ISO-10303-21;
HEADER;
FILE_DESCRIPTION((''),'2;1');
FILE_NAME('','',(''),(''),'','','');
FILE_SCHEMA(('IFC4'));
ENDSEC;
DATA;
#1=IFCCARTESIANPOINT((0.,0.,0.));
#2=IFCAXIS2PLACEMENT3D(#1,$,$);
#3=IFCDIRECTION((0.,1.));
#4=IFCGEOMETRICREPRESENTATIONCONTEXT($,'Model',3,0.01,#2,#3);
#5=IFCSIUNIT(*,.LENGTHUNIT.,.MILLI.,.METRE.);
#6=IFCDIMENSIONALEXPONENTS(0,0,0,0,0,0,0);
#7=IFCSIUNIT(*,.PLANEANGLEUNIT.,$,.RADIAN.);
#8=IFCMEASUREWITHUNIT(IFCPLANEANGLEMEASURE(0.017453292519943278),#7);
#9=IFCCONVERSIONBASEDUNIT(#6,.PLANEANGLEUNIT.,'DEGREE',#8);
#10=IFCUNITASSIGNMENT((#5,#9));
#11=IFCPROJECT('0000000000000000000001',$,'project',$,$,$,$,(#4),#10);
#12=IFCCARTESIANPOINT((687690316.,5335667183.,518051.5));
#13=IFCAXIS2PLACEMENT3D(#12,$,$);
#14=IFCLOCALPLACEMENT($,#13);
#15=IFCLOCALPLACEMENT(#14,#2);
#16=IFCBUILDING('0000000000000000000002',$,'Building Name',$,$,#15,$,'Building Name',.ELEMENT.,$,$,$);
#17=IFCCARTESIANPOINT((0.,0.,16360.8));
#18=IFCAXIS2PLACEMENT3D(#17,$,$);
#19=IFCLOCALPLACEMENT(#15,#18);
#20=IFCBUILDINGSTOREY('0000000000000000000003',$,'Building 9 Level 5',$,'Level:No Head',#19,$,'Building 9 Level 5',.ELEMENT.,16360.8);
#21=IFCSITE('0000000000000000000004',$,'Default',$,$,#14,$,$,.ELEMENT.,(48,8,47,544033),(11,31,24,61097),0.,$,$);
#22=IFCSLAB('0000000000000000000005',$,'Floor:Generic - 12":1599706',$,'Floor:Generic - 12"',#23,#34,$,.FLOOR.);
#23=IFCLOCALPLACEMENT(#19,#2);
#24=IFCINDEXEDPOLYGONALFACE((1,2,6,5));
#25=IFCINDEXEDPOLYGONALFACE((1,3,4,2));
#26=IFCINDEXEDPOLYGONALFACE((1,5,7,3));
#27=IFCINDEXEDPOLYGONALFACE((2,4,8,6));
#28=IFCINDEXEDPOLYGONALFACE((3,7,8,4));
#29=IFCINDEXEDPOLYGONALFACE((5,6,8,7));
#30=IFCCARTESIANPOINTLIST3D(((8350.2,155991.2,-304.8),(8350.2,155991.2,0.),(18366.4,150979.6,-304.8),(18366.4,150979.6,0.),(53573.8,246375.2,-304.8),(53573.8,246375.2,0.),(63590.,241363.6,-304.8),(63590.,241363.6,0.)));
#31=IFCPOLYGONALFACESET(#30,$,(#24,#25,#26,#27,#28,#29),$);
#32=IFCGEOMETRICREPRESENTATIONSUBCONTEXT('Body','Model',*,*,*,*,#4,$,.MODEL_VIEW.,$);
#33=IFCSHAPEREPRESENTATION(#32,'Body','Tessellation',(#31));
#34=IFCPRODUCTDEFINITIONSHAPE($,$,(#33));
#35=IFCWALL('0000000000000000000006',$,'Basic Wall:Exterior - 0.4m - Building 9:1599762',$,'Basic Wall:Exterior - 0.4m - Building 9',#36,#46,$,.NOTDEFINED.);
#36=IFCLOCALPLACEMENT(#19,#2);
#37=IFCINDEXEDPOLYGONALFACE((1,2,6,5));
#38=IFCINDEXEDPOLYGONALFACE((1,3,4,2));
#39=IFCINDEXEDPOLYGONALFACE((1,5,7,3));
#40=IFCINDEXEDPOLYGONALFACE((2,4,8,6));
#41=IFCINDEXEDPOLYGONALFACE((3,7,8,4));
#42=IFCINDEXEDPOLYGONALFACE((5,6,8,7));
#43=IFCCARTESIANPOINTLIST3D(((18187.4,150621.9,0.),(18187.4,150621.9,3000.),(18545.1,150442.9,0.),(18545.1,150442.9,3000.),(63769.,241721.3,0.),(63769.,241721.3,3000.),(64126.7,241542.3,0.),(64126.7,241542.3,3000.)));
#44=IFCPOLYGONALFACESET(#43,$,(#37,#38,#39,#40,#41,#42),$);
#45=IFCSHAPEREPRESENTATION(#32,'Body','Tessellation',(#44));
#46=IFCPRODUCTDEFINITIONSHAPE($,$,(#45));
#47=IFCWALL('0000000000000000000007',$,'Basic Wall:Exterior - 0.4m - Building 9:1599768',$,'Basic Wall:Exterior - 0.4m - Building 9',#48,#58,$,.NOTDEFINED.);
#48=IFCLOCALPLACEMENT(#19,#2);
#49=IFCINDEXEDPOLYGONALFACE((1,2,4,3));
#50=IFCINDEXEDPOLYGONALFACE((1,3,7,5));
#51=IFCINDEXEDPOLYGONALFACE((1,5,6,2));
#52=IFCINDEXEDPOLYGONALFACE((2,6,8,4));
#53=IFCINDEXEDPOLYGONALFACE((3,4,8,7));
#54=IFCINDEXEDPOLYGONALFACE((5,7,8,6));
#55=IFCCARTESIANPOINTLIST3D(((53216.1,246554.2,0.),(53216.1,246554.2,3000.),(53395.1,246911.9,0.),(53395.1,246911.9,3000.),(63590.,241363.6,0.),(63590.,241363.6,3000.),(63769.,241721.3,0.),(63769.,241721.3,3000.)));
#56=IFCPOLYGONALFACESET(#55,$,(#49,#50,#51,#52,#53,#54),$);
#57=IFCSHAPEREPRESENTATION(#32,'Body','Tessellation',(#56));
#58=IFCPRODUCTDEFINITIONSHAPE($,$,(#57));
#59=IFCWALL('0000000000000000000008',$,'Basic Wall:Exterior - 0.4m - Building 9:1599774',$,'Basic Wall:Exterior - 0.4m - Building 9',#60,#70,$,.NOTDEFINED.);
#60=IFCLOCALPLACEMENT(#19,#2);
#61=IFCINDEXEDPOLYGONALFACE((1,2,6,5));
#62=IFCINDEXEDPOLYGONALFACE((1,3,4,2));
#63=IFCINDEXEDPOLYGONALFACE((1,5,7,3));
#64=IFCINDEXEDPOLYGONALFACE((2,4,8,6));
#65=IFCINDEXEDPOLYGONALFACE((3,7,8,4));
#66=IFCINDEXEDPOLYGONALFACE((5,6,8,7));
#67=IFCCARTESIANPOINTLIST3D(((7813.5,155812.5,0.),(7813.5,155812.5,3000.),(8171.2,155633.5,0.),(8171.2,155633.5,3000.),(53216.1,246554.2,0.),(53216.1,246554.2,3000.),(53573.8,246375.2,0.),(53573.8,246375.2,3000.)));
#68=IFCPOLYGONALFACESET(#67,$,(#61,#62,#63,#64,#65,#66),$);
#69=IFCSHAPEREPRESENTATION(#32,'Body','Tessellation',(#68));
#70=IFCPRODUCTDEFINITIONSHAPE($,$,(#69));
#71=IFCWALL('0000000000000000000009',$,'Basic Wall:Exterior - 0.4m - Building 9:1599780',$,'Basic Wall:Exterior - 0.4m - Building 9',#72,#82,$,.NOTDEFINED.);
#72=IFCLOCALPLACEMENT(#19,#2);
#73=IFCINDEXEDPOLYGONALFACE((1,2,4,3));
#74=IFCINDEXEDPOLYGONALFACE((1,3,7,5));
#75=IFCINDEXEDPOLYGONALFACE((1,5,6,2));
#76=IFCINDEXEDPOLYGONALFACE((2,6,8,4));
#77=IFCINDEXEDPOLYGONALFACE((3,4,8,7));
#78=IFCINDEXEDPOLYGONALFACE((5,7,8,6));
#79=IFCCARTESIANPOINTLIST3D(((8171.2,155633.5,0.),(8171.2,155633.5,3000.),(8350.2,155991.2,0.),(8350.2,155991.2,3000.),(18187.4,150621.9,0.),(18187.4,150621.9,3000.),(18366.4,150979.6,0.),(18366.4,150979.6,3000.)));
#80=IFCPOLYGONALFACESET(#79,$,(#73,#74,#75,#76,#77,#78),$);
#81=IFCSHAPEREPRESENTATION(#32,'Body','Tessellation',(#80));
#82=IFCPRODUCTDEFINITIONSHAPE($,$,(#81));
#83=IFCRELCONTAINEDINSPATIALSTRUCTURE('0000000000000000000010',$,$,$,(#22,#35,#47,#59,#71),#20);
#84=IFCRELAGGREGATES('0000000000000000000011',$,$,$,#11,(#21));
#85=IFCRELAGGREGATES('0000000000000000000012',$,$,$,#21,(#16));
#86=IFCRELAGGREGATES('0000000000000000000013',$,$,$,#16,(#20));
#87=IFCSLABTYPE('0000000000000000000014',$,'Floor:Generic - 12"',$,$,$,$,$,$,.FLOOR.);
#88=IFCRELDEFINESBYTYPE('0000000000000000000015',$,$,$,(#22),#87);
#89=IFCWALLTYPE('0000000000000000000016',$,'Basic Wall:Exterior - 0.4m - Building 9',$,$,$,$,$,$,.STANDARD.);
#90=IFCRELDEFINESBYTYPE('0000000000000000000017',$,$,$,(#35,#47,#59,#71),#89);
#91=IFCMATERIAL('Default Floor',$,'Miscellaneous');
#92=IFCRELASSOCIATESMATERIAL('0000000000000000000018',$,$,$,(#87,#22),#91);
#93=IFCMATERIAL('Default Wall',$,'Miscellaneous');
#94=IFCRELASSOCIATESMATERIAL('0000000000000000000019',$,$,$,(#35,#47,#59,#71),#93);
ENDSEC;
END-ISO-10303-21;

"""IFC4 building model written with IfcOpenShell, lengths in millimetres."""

from ifc_helpers import new_model, entity, si_unit, converted_unit, direction, frame, origin, place, context, subcontext, project, spatial, indexed_curve, outline, extrude, material, type_object, element, save


model = new_model("IFC4")

# Units and contexts
model_context = context("Model", 3, precision=0.01, world=origin(), true_north=direction((0.0, 1.0)))
body_context = subcontext(model_context, "Body", "Model", "MODEL_VIEW")
ifc_project = project(units=[si_unit("LENGTHUNIT", "METRE", prefix="MILLI"), converted_unit("PLANEANGLEUNIT", "DEGREE", entity("IfcPlaneAngleMeasure", 0.017453292519943278), si_unit("PLANEANGLEUNIT", "RADIAN"), dimensions=[0, 0, 0, 0, 0, 0, 0])], contexts=[model_context])

# Site, building, storey
site_placement = place(None, frame((687690316.0, 5335667183.0, 518051.5)))
site = spatial("IfcSite", under=ifc_project, at=site_placement, Name="Default", CompositionType="ELEMENT", RefLatitude=(48, 8, 47, 544033), RefLongitude=(11, 31, 24, 61097), RefElevation=0.0)
building_placement = place(site_placement, origin())
building = spatial("IfcBuilding", under=site, at=building_placement, Name="Building Name", LongName="Building Name", CompositionType="ELEMENT")
storey_placement = place(building_placement, frame((0.0, 0.0, 16360.8)))
storey = spatial("IfcBuildingStorey", under=building, at=storey_placement, Name="Building 9 Level 5", ObjectType="Level:No Head", LongName="Building 9 Level 5", CompositionType="ELEMENT", Elevation=16360.8)

# Slab
ifc_material_1 = material(Name="Default Floor", Category="Miscellaneous")
slab_type = type_object("IfcSlabType", Name="Floor:Generic - 12\"", PredefinedType="FLOOR", material=ifc_material_1)
slab_placement = place(storey_placement, origin())
element("IfcSlab", 1, at=slab_placement, inside=storey, type_object=slab_type, material=ifc_material_1, Name="Floor:Generic - 12\":1599706", ObjectType="Floor:Generic - 12\"", PredefinedType="FLOOR", context=body_context, shape_type="SweptSolid", body=[
    extrude(outline(indexed_curve([(-50533.2, -5600.0), (50533.2, -5600.0), (50533.2, 5600.0), (-50533.2, 5600.0), (-50533.2, -5600.0)], self_intersect=False)), frame((35970.1, 198677.4, 0.0), z_axis=(0.0, 0.0, -1.0), x_axis=(-0.447464, -0.894302, 0.0)), (0.0, 0.0, 1.0), 304.8),
])

# Walls
ifc_material_2 = material(Name="Default Wall", Category="Miscellaneous")
wall_type = type_object("IfcWallType", Name="Basic Wall:Exterior - 0.4m - Building 9", PredefinedType="STANDARD")
wall_1_placement = place(storey_placement, frame((18366.3, 150532.4, 0.0), z_axis=(0.0, 0.0, 1.0), x_axis=(0.447464, 0.894302, 0.0)))
element("IfcWall", 2, at=wall_1_placement, inside=storey, type_object=wall_type, material=ifc_material_2, Name="Basic Wall:Exterior - 0.4m - Building 9:1599762", ObjectType="Basic Wall:Exterior - 0.4m - Building 9", PredefinedType="NOTDEFINED", context=body_context, shape_type="SweptSolid", body=[
    extrude(outline(indexed_curve([(101866.5, 200.0), (0.0, 200.0), (0.0, -200.0), (101866.5, -200.0), (101866.5, 200.0)], self_intersect=False)), origin(), (0.0, 0.0, 1.0), 3000.0),
])
wall_2_placement = place(storey_placement, frame((63679.5, 241542.5, 0.0), z_axis=(0.0, 0.0, 1.0), x_axis=(-0.894302, 0.447464, 0.0)))
element("IfcWall", 3, at=wall_2_placement, inside=storey, type_object=wall_type, material=ifc_material_2, Name="Basic Wall:Exterior - 0.4m - Building 9:1599768", ObjectType="Basic Wall:Exterior - 0.4m - Building 9", PredefinedType="NOTDEFINED", context=body_context, shape_type="SweptSolid", body=[
    extrude(outline(indexed_curve([(11600.0, 200.0), (0.0, 200.0), (0.0, -200.0), (11600.0, -200.0), (11600.0, 200.0)], self_intersect=False)), origin(), (0.0, 0.0, 1.0), 3000.0),
])
wall_3_placement = place(storey_placement, frame((53395.0, 246464.7, 0.0), z_axis=(0.0, 0.0, 1.0), x_axis=(-0.447464, -0.894302, 0.0)))
element("IfcWall", 4, at=wall_3_placement, inside=storey, type_object=wall_type, material=ifc_material_2, Name="Basic Wall:Exterior - 0.4m - Building 9:1599774", ObjectType="Basic Wall:Exterior - 0.4m - Building 9", PredefinedType="NOTDEFINED", context=body_context, shape_type="SweptSolid", body=[
    extrude(outline(indexed_curve([(101466.5, 200.0), (0.0, 200.0), (0.0, -200.0), (101466.5, -200.0), (101466.5, 200.0)], self_intersect=False)), origin(), (0.0, 0.0, 1.0), 3000.0),
])
wall_4_placement = place(storey_placement, frame((8260.7, 155812.4, 0.0), z_axis=(0.0, 0.0, 1.0), x_axis=(0.894302, -0.447464, 0.0)))
element("IfcWall", 5, at=wall_4_placement, inside=storey, type_object=wall_type, material=ifc_material_2, Name="Basic Wall:Exterior - 0.4m - Building 9:1599780", ObjectType="Basic Wall:Exterior - 0.4m - Building 9", PredefinedType="NOTDEFINED", context=body_context, shape_type="SweptSolid", body=[
    extrude(outline(indexed_curve([(11200.0, 200.0), (0.0, 200.0), (0.0, -200.0), (11200.0, -200.0), (11200.0, 200.0)], self_intersect=False)), origin(), (0.0, 0.0, 1.0), 3000.0),
])

save(model, "model.ifc")
